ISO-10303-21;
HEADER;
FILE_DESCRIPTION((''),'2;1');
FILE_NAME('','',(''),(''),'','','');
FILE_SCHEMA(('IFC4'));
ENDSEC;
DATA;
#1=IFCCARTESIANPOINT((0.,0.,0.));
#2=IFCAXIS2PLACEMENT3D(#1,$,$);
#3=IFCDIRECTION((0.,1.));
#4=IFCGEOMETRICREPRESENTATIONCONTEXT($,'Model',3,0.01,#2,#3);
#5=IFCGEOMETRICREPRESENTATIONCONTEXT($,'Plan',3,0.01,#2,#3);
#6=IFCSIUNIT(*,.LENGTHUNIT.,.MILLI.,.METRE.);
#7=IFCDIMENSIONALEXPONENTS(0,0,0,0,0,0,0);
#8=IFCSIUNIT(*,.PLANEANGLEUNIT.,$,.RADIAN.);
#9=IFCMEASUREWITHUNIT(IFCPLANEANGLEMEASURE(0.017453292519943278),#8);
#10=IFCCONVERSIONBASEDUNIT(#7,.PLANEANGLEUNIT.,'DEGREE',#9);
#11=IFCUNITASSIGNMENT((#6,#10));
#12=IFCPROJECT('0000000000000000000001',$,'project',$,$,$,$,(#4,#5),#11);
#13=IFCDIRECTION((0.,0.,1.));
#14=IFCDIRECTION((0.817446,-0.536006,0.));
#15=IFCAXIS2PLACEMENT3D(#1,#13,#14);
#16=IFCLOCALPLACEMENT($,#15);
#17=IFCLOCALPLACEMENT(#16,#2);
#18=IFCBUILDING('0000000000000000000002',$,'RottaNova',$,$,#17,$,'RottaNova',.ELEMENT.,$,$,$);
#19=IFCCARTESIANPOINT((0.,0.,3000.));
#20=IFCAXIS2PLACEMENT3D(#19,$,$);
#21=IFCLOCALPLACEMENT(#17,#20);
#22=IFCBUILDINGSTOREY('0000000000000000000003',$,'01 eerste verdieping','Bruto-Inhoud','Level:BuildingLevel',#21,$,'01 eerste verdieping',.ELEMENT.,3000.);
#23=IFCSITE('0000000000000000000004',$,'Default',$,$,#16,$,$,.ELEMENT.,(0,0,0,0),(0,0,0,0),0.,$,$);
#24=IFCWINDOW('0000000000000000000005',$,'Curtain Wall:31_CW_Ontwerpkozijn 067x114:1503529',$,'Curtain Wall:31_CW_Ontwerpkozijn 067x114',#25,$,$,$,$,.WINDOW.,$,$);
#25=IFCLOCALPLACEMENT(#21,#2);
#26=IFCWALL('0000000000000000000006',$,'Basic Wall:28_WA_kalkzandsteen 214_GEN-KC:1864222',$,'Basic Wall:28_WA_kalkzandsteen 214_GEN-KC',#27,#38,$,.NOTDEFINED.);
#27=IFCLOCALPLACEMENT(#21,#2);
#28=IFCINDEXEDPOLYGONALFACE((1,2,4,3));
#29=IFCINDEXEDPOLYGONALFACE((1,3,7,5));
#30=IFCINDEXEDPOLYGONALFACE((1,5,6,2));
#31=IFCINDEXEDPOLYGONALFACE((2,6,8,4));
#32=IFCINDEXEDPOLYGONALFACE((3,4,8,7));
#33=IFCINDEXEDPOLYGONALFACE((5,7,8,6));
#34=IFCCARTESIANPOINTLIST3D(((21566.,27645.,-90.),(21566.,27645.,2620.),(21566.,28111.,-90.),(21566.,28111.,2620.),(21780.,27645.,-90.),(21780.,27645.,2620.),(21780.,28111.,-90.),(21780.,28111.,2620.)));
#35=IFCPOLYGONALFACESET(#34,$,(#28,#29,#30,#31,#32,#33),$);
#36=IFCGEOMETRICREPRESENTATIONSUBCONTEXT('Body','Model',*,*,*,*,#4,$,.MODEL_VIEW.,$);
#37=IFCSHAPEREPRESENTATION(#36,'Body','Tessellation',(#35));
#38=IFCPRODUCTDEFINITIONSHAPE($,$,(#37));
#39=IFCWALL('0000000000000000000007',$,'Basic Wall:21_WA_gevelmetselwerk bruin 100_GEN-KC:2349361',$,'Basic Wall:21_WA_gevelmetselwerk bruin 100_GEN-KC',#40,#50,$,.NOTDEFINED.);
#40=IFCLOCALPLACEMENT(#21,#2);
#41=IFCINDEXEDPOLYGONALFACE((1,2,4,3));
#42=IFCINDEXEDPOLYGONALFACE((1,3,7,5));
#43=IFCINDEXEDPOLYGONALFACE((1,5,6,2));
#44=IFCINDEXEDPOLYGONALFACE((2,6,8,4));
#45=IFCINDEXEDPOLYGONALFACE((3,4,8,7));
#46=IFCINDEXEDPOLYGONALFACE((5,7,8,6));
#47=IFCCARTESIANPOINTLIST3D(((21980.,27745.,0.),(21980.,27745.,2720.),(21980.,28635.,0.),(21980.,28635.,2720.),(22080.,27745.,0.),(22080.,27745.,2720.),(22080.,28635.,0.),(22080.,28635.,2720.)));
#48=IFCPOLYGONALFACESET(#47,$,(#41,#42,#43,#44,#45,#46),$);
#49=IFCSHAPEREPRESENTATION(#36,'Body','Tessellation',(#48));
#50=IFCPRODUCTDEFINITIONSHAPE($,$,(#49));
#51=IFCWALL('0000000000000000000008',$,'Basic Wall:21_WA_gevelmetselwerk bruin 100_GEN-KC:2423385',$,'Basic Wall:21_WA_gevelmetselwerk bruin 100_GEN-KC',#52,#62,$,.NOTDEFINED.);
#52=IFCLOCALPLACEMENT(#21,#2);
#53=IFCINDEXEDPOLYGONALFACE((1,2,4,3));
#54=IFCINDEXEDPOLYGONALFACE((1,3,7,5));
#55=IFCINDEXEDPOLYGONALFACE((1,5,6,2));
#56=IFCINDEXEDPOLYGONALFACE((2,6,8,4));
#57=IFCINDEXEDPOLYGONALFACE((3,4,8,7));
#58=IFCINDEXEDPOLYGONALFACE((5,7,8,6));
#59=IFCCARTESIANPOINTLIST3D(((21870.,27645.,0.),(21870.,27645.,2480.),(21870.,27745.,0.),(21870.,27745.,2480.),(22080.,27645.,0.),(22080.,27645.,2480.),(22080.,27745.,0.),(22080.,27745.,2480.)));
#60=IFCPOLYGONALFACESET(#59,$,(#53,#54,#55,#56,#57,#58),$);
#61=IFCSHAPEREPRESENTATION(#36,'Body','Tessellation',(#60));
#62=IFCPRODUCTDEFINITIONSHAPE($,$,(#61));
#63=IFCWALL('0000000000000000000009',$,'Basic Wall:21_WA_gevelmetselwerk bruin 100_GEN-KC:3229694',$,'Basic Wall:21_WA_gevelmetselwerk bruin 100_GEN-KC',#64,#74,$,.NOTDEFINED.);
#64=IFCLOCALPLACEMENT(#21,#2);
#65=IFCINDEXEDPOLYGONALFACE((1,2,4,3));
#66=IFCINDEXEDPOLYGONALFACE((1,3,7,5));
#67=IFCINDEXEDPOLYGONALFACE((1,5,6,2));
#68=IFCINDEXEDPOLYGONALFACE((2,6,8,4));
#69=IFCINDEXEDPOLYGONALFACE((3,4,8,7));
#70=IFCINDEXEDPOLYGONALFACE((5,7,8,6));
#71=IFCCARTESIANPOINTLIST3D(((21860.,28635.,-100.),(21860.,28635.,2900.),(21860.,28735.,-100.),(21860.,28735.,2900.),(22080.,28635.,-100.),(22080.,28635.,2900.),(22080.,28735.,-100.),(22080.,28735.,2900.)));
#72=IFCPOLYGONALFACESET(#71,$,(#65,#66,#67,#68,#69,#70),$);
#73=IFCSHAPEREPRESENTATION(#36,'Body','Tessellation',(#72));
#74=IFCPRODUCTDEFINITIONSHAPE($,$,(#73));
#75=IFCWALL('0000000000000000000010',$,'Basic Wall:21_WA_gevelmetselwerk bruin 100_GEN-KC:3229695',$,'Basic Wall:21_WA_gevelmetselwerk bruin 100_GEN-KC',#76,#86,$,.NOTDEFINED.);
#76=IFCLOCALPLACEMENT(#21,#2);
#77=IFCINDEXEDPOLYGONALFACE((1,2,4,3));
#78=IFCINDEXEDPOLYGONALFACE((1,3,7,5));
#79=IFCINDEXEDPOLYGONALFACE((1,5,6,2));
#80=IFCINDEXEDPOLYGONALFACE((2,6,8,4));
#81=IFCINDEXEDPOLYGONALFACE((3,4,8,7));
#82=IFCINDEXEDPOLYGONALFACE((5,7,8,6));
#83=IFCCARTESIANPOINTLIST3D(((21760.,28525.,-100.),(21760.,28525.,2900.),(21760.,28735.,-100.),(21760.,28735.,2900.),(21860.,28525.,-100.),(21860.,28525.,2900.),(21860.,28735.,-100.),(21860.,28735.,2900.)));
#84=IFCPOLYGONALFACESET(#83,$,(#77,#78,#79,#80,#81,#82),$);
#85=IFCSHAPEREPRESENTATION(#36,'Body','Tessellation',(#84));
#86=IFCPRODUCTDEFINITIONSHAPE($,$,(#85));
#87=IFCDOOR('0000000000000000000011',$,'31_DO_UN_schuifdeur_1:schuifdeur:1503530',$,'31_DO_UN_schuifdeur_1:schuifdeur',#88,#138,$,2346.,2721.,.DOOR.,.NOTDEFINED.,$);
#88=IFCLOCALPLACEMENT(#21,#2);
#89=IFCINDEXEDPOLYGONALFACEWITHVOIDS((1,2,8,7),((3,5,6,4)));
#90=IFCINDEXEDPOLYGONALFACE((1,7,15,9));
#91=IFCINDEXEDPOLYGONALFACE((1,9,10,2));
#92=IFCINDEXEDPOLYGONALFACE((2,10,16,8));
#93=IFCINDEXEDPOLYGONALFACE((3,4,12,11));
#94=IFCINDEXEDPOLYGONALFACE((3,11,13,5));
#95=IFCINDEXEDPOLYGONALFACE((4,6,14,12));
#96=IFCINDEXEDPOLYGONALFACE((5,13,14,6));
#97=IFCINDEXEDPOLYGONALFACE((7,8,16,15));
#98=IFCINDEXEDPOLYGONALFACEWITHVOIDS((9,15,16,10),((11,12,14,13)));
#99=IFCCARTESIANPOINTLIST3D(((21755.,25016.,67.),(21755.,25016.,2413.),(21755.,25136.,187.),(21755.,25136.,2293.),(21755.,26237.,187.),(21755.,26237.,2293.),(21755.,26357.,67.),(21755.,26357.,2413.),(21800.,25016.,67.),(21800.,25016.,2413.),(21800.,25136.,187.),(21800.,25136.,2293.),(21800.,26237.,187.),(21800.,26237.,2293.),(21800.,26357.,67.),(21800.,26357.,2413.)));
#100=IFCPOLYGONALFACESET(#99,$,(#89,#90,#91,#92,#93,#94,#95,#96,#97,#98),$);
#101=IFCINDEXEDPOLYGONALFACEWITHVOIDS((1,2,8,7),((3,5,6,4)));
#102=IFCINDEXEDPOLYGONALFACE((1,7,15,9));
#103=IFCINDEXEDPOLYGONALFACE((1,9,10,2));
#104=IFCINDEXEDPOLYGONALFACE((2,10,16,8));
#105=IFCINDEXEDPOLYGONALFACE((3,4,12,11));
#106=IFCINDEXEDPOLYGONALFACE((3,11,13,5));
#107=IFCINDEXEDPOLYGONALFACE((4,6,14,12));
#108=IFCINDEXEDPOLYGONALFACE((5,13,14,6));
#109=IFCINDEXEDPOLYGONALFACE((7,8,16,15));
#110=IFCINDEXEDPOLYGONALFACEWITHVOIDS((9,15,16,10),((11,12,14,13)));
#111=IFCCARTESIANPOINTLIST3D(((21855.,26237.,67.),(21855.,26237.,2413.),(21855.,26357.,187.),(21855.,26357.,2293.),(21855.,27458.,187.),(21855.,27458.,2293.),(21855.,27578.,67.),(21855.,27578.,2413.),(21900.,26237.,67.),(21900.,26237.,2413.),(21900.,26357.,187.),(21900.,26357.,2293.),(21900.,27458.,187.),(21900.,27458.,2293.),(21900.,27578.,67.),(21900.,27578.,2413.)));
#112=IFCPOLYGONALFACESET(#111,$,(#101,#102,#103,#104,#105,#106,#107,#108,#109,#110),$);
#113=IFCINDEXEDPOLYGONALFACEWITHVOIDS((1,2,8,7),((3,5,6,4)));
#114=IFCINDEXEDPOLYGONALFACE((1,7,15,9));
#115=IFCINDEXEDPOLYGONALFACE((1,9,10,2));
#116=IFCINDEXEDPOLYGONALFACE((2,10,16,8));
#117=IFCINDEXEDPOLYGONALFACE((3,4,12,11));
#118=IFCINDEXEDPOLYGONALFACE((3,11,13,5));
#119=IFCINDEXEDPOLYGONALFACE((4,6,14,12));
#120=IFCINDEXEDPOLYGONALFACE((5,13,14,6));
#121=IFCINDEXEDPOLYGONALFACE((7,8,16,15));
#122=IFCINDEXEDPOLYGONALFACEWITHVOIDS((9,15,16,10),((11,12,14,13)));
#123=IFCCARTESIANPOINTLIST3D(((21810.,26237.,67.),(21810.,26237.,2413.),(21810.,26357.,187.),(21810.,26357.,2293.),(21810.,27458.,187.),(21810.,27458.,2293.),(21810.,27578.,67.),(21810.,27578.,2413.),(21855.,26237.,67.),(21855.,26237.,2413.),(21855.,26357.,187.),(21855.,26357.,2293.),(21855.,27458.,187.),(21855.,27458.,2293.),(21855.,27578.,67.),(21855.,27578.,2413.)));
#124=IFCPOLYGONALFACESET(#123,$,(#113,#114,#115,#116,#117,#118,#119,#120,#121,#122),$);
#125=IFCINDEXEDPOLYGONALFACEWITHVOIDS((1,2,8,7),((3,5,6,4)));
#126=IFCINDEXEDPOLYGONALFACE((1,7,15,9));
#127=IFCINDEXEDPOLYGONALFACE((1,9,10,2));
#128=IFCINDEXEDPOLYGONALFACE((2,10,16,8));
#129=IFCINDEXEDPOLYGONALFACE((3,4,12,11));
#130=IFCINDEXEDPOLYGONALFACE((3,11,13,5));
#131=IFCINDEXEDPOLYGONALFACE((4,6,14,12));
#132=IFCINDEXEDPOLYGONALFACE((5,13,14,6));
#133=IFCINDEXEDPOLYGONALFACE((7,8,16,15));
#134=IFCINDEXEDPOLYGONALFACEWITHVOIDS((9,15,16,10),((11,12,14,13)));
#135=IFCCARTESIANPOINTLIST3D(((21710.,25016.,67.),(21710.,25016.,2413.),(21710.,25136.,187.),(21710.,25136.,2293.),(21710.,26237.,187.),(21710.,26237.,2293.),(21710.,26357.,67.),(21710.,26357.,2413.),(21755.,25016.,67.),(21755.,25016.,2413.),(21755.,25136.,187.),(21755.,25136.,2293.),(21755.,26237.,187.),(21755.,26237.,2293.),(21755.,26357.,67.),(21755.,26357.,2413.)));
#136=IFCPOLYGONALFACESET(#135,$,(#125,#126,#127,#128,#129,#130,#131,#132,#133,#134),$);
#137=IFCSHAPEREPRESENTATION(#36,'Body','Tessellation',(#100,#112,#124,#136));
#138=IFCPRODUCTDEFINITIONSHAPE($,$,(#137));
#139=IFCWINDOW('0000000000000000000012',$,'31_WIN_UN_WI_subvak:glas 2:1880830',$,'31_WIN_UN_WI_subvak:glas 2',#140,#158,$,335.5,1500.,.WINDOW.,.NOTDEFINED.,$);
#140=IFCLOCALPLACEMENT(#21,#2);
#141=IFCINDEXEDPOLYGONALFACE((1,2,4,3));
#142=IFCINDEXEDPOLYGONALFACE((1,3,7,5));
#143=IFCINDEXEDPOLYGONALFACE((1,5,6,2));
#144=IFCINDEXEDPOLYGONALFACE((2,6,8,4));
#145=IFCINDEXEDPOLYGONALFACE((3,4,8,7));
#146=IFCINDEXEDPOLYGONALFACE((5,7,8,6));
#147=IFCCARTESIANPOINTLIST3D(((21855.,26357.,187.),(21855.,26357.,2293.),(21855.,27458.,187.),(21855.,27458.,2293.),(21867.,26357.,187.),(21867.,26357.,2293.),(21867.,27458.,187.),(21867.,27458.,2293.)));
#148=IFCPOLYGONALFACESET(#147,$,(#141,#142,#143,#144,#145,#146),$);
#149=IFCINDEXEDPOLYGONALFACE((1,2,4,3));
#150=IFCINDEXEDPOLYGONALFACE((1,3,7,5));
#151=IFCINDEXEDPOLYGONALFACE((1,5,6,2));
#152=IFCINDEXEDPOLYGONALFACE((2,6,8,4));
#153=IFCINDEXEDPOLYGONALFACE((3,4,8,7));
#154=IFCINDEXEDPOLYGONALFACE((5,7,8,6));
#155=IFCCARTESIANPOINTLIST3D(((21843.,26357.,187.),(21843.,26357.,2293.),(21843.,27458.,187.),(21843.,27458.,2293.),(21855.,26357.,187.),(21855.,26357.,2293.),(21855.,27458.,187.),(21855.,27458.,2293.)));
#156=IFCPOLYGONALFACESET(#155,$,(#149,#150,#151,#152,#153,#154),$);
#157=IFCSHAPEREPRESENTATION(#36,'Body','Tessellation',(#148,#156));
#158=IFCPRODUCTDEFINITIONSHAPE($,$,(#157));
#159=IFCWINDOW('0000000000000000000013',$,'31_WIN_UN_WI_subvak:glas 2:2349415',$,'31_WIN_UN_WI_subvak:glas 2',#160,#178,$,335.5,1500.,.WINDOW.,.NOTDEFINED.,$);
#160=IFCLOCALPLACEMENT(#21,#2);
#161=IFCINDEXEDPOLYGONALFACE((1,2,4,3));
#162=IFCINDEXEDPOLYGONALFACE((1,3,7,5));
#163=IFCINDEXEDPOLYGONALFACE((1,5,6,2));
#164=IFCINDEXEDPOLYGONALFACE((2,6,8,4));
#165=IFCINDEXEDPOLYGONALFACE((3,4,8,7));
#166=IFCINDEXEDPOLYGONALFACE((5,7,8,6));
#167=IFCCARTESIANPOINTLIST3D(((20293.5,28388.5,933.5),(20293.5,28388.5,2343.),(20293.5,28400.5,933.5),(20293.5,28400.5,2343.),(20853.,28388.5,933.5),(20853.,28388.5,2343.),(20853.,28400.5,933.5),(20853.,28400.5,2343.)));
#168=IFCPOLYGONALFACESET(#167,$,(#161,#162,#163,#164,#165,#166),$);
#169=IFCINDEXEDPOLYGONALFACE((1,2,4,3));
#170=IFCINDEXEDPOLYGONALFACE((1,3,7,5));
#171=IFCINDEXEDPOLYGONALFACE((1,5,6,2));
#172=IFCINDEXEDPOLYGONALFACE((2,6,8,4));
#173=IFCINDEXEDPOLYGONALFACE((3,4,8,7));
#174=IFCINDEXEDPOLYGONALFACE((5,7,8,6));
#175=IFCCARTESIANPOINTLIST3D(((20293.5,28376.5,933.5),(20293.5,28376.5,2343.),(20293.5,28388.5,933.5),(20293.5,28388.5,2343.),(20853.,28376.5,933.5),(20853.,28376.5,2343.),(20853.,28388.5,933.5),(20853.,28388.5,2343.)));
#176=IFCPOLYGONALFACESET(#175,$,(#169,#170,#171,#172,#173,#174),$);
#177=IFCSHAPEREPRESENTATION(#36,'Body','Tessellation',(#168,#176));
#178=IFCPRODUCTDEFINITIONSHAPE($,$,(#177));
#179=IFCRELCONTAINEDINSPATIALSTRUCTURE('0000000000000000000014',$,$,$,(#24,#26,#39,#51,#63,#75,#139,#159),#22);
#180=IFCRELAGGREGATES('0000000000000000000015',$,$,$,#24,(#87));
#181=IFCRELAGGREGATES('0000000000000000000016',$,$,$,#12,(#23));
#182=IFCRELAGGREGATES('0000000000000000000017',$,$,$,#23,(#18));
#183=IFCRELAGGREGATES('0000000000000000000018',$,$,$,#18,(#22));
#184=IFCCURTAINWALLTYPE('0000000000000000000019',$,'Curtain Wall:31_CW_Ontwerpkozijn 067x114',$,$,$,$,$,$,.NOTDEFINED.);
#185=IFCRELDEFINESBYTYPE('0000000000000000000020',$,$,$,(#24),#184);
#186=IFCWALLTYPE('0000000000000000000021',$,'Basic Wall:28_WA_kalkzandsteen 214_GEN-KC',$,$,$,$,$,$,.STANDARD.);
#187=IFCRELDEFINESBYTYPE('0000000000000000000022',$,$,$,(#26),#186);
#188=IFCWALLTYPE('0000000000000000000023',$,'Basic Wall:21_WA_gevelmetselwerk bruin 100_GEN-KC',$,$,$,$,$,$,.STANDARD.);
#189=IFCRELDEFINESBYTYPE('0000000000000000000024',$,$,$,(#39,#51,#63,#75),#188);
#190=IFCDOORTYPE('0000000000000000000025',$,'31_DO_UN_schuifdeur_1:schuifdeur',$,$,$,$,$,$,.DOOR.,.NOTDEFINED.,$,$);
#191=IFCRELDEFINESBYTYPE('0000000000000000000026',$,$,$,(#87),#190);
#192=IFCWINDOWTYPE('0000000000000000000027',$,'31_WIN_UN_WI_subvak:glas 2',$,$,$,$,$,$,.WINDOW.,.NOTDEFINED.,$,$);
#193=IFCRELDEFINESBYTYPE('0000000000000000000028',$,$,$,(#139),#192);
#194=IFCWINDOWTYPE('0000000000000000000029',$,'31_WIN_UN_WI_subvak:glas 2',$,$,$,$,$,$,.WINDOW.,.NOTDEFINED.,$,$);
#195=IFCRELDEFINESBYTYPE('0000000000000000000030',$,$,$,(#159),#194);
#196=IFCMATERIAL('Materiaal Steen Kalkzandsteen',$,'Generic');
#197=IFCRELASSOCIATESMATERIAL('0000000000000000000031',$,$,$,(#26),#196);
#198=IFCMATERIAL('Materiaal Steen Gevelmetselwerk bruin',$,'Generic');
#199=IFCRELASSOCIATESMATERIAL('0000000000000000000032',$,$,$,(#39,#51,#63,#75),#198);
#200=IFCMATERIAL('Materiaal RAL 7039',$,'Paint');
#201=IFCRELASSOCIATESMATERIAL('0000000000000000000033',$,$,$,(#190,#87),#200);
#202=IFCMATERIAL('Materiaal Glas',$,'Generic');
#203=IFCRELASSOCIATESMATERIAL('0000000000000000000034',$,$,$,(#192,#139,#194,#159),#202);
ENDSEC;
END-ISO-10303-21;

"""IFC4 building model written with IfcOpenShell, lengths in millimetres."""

from ifc_helpers import new_model, entity, si_unit, converted_unit, direction, frame, origin, place, context, subcontext, project, spatial, indexed_curve, outline, extrude, source, transform, mapped, material, type_object, type_shapes, element, aggregate, save


model = new_model("IFC4")

# Units and contexts
model_context = context("Model", 3, precision=0.01, world=origin(), true_north=direction((0.0, 1.0)))
plan_context = context("Plan", 3, precision=0.01, world=origin(), true_north=direction((0.0, 1.0)))
body_context = subcontext(model_context, "Body", "Model", "MODEL_VIEW")
ifc_project = project(units=[si_unit("LENGTHUNIT", "METRE", prefix="MILLI"), converted_unit("PLANEANGLEUNIT", "DEGREE", entity("IfcPlaneAngleMeasure", 0.017453292519943278), si_unit("PLANEANGLEUNIT", "RADIAN"), dimensions=[0, 0, 0, 0, 0, 0, 0])], contexts=[model_context, plan_context])

# Site, building, storey
site_placement = place(None, frame((0.0, 0.0, 0.0), z_axis=(0.0, 0.0, 1.0), x_axis=(0.817446, -0.536006, 0.0)))
site = spatial("IfcSite", under=ifc_project, at=site_placement, Name="Default", CompositionType="ELEMENT", RefLatitude=(0, 0, 0, 0), RefLongitude=(0, 0, 0, 0), RefElevation=0.0)
building_placement = place(site_placement, origin())
building = spatial("IfcBuilding", under=site, at=building_placement, Name="RottaNova", LongName="RottaNova", CompositionType="ELEMENT")
storey_placement = place(building_placement, frame((0.0, 0.0, 3000.0)))
storey = spatial("IfcBuildingStorey", under=building, at=storey_placement, Name="01 eerste verdieping", Description="Bruto-Inhoud", ObjectType="Level:BuildingLevel", LongName="01 eerste verdieping", CompositionType="ELEMENT", Elevation=3000.0)

# Window
curtain_wall_type = type_object("IfcCurtainWallType", Name="Curtain Wall:31_CW_Ontwerpkozijn 067x114", PredefinedType="NOTDEFINED")
window_1_placement = place(storey_placement, frame((0.0, 0.0, -3000.0)))
window_1 = element("IfcWindow", 1, at=window_1_placement, inside=storey, type_object=curtain_wall_type, Name="Curtain Wall:31_CW_Ontwerpkozijn 067x114:1503529", ObjectType="Curtain Wall:31_CW_Ontwerpkozijn 067x114", PredefinedType="WINDOW")
ifc_material_1 = material(Name="Materiaal RAL 7039", Category="Paint")

# Shared definitions
ifc_material_2 = material(Name="Materiaal Glas", Category="Generic")

# Walls
ifc_material_3 = material(Name="Materiaal Steen Kalkzandsteen", Category="Generic")
wall_type_1 = type_object("IfcWallType", Name="Basic Wall:28_WA_kalkzandsteen 214_GEN-KC", PredefinedType="STANDARD")
wall_1_placement = place(storey_placement, frame((21673.0, 28111.0, -90.0), z_axis=(0.0, 0.0, 1.0), x_axis=(0.0, -1.0, 0.0)))
element("IfcWall", 2, at=wall_1_placement, inside=storey, type_object=wall_type_1, material=ifc_material_3, Name="Basic Wall:28_WA_kalkzandsteen 214_GEN-KC:1864222", ObjectType="Basic Wall:28_WA_kalkzandsteen 214_GEN-KC", PredefinedType="NOTDEFINED", context=body_context, shape_type="SweptSolid", body=[
    extrude(outline(indexed_curve([(466.0, 107.0), (0.0, 107.0), (0.0, -107.0), (466.0, -107.0), (466.0, 107.0)], self_intersect=False)), origin(), (0.0, 0.0, 1.0), 2710.0),
])
ifc_material_4 = material(Name="Materiaal Steen Gevelmetselwerk bruin", Category="Generic")
wall_type_2 = type_object("IfcWallType", Name="Basic Wall:21_WA_gevelmetselwerk bruin 100_GEN-KC", PredefinedType="STANDARD")
wall_2_placement = place(storey_placement, frame((22030.0, 27745.0, 0.0), z_axis=(0.0, 0.0, 1.0), x_axis=(0.0, 1.0, 0.0)))
element("IfcWall", 3, at=wall_2_placement, inside=storey, type_object=wall_type_2, material=ifc_material_4, Name="Basic Wall:21_WA_gevelmetselwerk bruin 100_GEN-KC:2349361", ObjectType="Basic Wall:21_WA_gevelmetselwerk bruin 100_GEN-KC", PredefinedType="NOTDEFINED", context=body_context, shape_type="SweptSolid", body=[
    extrude(outline(indexed_curve([(890.0, 50.0), (0.0, 50.0), (0.0, -50.0), (890.0, -50.0), (890.0, 50.0)], self_intersect=False)), origin(), (0.0, 0.0, 1.0), 2720.0),
])
wall_3_placement = place(storey_placement, frame((21870.0, 27695.0, 0.0)))
element("IfcWall", 4, at=wall_3_placement, inside=storey, type_object=wall_type_2, material=ifc_material_4, Name="Basic Wall:21_WA_gevelmetselwerk bruin 100_GEN-KC:2423385", ObjectType="Basic Wall:21_WA_gevelmetselwerk bruin 100_GEN-KC", PredefinedType="NOTDEFINED", context=body_context, shape_type="SweptSolid", body=[
    extrude(outline(indexed_curve([(210.0, 50.0), (0.0, 50.0), (0.0, -50.0), (210.0, -50.0), (210.0, 50.0)], self_intersect=False)), origin(), (0.0, 0.0, 1.0), 2480.0),
])
wall_4_placement = place(storey_placement, frame((21860.0, 28685.0, -100.0)))
element("IfcWall", 5, at=wall_4_placement, inside=storey, type_object=wall_type_2, material=ifc_material_4, Name="Basic Wall:21_WA_gevelmetselwerk bruin 100_GEN-KC:3229694", ObjectType="Basic Wall:21_WA_gevelmetselwerk bruin 100_GEN-KC", PredefinedType="NOTDEFINED", context=body_context, shape_type="SweptSolid", body=[
    extrude(outline(indexed_curve([(220.0, 50.0), (0.0, 50.0), (0.0, -50.0), (220.0, -50.0), (220.0, 50.0)], self_intersect=False)), origin(), (0.0, 0.0, 1.0), 3000.0),
])
wall_5_placement = place(storey_placement, frame((21810.0, 28735.0, -100.0), z_axis=(0.0, 0.0, 1.0), x_axis=(0.0, -1.0, 0.0)))
element("IfcWall", 6, at=wall_5_placement, inside=storey, type_object=wall_type_2, material=ifc_material_4, Name="Basic Wall:21_WA_gevelmetselwerk bruin 100_GEN-KC:3229695", ObjectType="Basic Wall:21_WA_gevelmetselwerk bruin 100_GEN-KC", PredefinedType="NOTDEFINED", context=body_context, shape_type="SweptSolid", body=[
    extrude(outline(indexed_curve([(210.0, 50.0), (0.0, 50.0), (0.0, -50.0), (210.0, -50.0), (210.0, 50.0)], self_intersect=False)), origin(), (0.0, 0.0, 1.0), 3000.0),
])

# Door
door_type = type_object("IfcDoorType", Name="31_DO_UN_schuifdeur_1:schuifdeur", OperationType="NOTDEFINED", PredefinedType="DOOR", material=ifc_material_1)
shared_shape_1 = source(origin(), body_context, "Body", "SweptSolid", [
    extrude(outline(indexed_curve([(-670.5, -1173.0), (670.5, -1173.0), (670.5, 1173.0), (-670.5, 1173.0), (-670.5, -1173.0)], self_intersect=False), holes=[indexed_curve([(-550.5, -1053.0), (-550.5, 1053.0), (550.5, 1053.0), (550.5, -1053.0), (-550.5, -1053.0)], self_intersect=False)]), frame((610.5, 45.0, 1173.0), z_axis=(0.0, 1.0, 0.0), x_axis=(1.0, 0.0, 0.0)), (0.0, 0.0, 1.0), 45.0),
    extrude(outline(indexed_curve([(-670.5, -1173.0), (670.5, -1173.0), (670.5, 1173.0), (-670.5, 1173.0), (-670.5, -1173.0)], self_intersect=False), holes=[indexed_curve([(-550.5, -1053.0), (-550.5, 1053.0), (550.5, 1053.0), (550.5, -1053.0), (-550.5, -1053.0)], self_intersect=False)]), frame((-610.5, 145.0, 1173.0), z_axis=(0.0, 1.0, 0.0), x_axis=(1.0, 0.0, 0.0)), (0.0, 0.0, 1.0), 45.0),
    extrude(outline(indexed_curve([(-670.5, -1173.0), (670.5, -1173.0), (670.5, 1173.0), (-670.5, 1173.0), (-670.5, -1173.0)], self_intersect=False), holes=[indexed_curve([(-550.5, -1053.0), (-550.5, 1053.0), (550.5, 1053.0), (550.5, -1053.0), (-550.5, -1053.0)], self_intersect=False)]), frame((-610.5, 100.0, 1173.0), z_axis=(0.0, 1.0, 0.0), x_axis=(1.0, 0.0, 0.0)), (0.0, 0.0, 1.0), 45.0),
    extrude(outline(indexed_curve([(-670.5, -1173.0), (670.5, -1173.0), (670.5, 1173.0), (-670.5, 1173.0), (-670.5, -1173.0)], self_intersect=False), holes=[indexed_curve([(-550.5, -1053.0), (-550.5, 1053.0), (550.5, 1053.0), (550.5, -1053.0), (-550.5, -1053.0)], self_intersect=False)]), frame((610.5, 0.0, 1173.0), z_axis=(0.0, 1.0, 0.0), x_axis=(1.0, 0.0, 0.0)), (0.0, 0.0, 1.0), 45.0),
])
type_shapes(door_type, [shared_shape_1])
door_placement = place(window_1_placement, frame((21710.0, 26297.0, 3067.0), z_axis=(0.0, 0.0, 1.0), x_axis=(0.0, -1.0, 0.0)))
door = element("IfcDoor", 7, at=door_placement, type_object=door_type, material=ifc_material_1, Name="31_DO_UN_schuifdeur_1:schuifdeur:1503530", ObjectType="31_DO_UN_schuifdeur_1:schuifdeur", OperationType="NOTDEFINED", OverallHeight=2346.0, OverallWidth=2721.0, PredefinedType="DOOR", context=body_context, shape_type="MappedRepresentation", body=[
    mapped(shared_shape_1, transform((0.0, 0.0, 0.0), scale=1.0)),
])
aggregate(window_1, [door])

# Windows
window_type_1 = type_object("IfcWindowType", Name="31_WIN_UN_WI_subvak:glas 2", PartitioningType="NOTDEFINED", PredefinedType="WINDOW", material=ifc_material_2)
shared_shape_2 = source(origin(), body_context, "Body", "SweptSolid", [
    extrude(outline(indexed_curve([(-6.0, -550.5), (6.0, -550.5), (6.0, 550.5), (-6.0, 550.5), (-6.0, -550.5)], self_intersect=False)), frame((0.0, 6.0, 0.0), z_axis=(0.0, 0.0, 1.0), x_axis=(0.0, -1.0, 0.0)), (0.0, 0.0, 1.0), 2106.0),
    extrude(outline(indexed_curve([(-6.0, -550.5), (6.0, -550.5), (6.0, 550.5), (-6.0, 550.5), (-6.0, -550.5)], self_intersect=False)), frame((0.0, -6.0, 0.0), z_axis=(0.0, 0.0, 1.0), x_axis=(0.0, -1.0, 0.0)), (0.0, 0.0, 1.0), 2106.0),
])
type_shapes(window_type_1, [shared_shape_2])
window_2_placement = place(storey_placement, frame((21855.0, 26907.5, 187.0), z_axis=(0.0, 0.0, 1.0), x_axis=(0.0, -1.0, 0.0)))
element("IfcWindow", 8, at=window_2_placement, inside=storey, type_object=window_type_1, material=ifc_material_2, Name="31_WIN_UN_WI_subvak:glas 2:1880830", ObjectType="31_WIN_UN_WI_subvak:glas 2", OverallHeight=335.5, OverallWidth=1500.0, PartitioningType="NOTDEFINED", PredefinedType="WINDOW", context=body_context, shape_type="MappedRepresentation", body=[
    mapped(shared_shape_2, transform((0.0, 0.0, 0.0), scale=1.0)),
])
window_type_2 = type_object("IfcWindowType", Name="31_WIN_UN_WI_subvak:glas 2", PartitioningType="NOTDEFINED", PredefinedType="WINDOW", material=ifc_material_2)
shared_shape_3 = source(origin(), body_context, "Body", "SweptSolid", [
    extrude(outline(indexed_curve([(-6.0, -279.8), (6.0, -279.8), (6.0, 279.8), (-6.0, 279.8), (-6.0, -279.8)], self_intersect=False)), frame((0.0, 6.0, 0.0), z_axis=(0.0, 0.0, 1.0), x_axis=(0.0, -1.0, 0.0)), (0.0, 0.0, 1.0), 1409.5),
    extrude(outline(indexed_curve([(-6.0, -279.8), (6.0, -279.8), (6.0, 279.8), (-6.0, 279.8), (-6.0, -279.8)], self_intersect=False)), frame((0.0, -6.0, 0.0), z_axis=(0.0, 0.0, 1.0), x_axis=(0.0, -1.0, 0.0)), (0.0, 0.0, 1.0), 1409.5),
])
type_shapes(window_type_2, [shared_shape_3])
window_3_placement = place(storey_placement, frame((20573.3, 28388.5, 933.5)))
element("IfcWindow", 9, at=window_3_placement, inside=storey, type_object=window_type_2, material=ifc_material_2, Name="31_WIN_UN_WI_subvak:glas 2:2349415", ObjectType="31_WIN_UN_WI_subvak:glas 2", OverallHeight=335.5, OverallWidth=1500.0, PartitioningType="NOTDEFINED", PredefinedType="WINDOW", context=body_context, shape_type="MappedRepresentation", body=[
    mapped(shared_shape_3, transform((0.0, 0.0, 0.0), scale=1.0)),
])

save(model, "model.ifc")
